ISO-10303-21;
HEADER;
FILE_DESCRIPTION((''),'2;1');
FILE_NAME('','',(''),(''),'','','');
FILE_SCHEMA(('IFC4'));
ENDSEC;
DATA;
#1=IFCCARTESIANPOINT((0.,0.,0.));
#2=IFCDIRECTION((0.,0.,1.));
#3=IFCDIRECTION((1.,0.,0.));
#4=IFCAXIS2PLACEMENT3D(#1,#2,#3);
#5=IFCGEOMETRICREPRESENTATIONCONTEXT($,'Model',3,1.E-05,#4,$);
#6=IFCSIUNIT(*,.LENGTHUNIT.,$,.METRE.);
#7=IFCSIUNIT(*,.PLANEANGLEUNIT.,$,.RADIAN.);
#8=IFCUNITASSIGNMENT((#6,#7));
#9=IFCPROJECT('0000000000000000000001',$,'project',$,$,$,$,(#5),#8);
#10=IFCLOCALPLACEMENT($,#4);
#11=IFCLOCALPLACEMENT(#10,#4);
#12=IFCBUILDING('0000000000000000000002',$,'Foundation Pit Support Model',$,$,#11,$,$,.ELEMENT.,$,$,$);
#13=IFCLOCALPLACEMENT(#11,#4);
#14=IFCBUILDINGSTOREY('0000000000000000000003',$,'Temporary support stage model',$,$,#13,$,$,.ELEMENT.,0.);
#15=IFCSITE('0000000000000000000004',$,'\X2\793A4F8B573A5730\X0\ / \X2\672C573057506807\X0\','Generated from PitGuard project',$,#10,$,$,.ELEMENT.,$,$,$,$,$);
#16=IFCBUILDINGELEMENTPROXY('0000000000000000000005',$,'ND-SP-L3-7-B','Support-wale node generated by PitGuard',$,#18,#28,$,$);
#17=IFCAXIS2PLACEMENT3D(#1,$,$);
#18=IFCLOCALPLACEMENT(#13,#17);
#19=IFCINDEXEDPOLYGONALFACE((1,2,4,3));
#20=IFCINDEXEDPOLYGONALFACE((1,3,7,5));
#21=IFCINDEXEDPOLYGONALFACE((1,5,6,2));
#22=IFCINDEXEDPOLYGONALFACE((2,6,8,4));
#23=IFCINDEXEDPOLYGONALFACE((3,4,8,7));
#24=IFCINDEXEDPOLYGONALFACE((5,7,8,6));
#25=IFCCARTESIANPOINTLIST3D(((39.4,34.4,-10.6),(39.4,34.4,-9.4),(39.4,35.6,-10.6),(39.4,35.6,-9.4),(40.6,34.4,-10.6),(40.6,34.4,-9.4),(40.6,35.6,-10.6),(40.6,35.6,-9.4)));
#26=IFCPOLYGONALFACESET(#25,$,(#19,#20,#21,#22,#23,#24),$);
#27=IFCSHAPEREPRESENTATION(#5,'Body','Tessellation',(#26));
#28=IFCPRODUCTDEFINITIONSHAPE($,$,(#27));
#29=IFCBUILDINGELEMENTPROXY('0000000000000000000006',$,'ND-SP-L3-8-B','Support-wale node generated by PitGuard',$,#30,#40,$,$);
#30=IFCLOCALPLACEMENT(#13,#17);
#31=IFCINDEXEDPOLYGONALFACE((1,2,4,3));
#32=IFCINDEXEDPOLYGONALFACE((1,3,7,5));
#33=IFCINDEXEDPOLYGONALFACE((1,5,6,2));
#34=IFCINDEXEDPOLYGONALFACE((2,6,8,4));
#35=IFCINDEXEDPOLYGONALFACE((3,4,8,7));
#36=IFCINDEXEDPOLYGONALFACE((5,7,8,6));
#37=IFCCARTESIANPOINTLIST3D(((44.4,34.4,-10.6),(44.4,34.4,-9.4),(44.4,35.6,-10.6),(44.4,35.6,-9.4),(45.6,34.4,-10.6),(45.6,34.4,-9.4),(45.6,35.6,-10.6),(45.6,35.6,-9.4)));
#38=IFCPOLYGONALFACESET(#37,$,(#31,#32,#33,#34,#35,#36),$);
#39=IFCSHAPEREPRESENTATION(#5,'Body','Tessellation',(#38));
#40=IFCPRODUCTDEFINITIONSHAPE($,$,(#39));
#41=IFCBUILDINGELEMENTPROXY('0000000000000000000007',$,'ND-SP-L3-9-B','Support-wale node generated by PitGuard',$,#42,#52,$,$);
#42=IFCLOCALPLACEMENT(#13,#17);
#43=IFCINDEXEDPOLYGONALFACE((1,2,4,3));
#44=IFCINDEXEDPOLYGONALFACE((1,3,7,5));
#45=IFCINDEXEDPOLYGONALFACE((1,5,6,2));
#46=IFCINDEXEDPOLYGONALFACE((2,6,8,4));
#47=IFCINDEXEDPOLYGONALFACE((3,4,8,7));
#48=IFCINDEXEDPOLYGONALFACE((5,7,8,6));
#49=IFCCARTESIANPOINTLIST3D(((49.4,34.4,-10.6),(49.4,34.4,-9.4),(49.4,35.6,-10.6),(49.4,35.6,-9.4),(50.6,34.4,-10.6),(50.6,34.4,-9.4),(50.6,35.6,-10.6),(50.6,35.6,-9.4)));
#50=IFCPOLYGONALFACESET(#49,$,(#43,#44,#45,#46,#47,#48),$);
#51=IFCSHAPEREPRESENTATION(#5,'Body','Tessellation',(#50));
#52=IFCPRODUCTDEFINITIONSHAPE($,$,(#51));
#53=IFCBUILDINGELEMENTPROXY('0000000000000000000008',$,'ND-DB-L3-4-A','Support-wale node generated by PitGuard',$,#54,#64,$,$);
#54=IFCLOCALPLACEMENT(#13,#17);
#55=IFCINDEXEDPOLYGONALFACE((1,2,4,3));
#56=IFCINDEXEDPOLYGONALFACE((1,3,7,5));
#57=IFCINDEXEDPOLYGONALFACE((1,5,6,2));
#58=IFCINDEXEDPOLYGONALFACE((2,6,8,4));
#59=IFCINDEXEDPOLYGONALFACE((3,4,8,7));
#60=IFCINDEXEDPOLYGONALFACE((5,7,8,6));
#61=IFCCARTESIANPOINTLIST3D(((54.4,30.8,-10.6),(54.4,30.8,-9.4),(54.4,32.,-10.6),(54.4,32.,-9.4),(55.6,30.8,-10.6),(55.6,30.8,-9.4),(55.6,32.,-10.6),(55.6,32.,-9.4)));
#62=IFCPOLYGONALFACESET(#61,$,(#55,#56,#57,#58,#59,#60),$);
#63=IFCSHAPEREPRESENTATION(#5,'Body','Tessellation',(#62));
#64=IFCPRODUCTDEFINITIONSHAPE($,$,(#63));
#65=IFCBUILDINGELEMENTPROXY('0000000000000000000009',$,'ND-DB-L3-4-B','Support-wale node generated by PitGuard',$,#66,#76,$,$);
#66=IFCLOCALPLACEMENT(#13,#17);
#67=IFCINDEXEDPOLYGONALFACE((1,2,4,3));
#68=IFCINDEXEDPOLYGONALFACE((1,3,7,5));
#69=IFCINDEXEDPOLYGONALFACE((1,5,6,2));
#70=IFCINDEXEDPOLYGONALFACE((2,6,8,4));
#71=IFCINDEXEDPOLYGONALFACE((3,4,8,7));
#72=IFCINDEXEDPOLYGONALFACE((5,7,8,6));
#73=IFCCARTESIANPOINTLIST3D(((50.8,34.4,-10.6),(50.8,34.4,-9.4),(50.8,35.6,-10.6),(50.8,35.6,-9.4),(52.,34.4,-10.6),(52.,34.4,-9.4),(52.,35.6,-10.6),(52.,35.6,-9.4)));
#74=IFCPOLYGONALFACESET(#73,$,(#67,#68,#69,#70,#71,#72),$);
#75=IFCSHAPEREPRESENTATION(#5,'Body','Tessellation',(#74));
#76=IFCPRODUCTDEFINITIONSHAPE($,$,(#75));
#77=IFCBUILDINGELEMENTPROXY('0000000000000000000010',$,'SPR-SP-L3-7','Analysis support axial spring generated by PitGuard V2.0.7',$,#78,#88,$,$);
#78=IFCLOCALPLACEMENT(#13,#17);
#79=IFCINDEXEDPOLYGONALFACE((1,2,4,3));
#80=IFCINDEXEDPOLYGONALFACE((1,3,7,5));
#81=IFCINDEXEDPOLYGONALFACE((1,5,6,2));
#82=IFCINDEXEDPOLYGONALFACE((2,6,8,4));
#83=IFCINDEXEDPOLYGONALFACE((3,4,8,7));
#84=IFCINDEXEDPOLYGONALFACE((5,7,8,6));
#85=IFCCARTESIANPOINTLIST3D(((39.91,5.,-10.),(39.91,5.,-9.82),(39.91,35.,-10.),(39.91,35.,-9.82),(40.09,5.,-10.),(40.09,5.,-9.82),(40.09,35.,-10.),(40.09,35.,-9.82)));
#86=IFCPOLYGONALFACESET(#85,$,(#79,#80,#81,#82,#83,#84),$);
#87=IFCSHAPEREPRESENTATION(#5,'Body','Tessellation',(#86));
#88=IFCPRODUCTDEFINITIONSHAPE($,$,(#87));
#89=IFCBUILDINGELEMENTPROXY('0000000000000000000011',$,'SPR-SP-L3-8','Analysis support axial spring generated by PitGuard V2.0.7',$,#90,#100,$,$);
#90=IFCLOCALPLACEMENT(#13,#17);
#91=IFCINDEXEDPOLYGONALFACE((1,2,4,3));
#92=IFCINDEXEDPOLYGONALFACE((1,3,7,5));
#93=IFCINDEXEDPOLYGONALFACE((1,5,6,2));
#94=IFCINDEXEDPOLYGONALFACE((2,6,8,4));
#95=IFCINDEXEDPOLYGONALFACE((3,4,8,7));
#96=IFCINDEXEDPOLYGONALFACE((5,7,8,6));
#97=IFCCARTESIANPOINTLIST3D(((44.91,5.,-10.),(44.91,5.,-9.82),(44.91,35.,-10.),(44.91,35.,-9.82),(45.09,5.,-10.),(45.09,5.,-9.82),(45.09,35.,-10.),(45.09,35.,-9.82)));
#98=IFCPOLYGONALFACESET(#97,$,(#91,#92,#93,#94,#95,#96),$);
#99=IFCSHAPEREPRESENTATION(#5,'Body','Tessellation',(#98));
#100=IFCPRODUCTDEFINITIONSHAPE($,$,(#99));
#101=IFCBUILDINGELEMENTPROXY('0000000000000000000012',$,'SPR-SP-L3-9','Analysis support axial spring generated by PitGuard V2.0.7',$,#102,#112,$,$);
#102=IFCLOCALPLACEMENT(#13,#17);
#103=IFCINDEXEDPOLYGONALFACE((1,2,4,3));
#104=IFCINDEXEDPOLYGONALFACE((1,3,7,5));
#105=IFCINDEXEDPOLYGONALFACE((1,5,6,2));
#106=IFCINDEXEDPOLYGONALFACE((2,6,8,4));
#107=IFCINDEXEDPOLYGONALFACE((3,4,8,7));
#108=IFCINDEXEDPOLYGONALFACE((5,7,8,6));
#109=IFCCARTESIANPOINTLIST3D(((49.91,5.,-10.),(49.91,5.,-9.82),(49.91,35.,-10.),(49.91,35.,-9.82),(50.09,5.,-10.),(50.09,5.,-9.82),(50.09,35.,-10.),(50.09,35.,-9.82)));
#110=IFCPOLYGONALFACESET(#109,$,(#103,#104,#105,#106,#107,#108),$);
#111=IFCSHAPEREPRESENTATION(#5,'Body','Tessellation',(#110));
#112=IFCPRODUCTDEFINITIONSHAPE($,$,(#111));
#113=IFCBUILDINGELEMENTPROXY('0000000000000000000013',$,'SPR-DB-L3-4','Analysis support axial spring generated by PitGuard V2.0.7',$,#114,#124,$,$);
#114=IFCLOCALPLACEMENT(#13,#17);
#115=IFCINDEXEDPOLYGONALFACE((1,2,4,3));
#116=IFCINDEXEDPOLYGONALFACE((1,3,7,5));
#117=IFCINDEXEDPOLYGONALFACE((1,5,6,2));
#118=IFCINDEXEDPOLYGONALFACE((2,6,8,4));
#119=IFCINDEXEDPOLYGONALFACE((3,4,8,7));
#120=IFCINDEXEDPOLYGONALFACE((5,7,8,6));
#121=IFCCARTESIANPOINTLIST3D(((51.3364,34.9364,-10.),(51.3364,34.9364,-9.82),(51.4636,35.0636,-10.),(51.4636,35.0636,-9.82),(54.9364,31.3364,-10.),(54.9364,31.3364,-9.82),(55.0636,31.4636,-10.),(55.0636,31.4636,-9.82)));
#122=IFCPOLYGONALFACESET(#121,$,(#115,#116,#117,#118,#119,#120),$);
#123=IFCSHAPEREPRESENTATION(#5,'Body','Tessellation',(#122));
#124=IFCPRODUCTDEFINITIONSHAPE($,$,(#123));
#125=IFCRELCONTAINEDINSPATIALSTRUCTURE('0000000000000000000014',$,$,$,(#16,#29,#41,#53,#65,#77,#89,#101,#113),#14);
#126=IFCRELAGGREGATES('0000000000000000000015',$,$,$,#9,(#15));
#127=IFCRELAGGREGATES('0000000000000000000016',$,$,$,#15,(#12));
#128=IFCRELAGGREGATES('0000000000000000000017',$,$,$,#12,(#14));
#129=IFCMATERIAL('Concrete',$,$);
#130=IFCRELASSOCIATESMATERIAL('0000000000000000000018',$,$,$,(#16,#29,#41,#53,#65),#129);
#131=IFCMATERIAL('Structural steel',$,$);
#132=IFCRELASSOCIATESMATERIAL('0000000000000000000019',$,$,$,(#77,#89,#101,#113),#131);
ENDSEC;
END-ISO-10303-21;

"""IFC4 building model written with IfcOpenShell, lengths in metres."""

from ifc_helpers import new_model, si_unit, frame, origin_with_axes, origin_2d, place, context, project, spatial, rectangle, extrude, material, element, save


model = new_model("IFC4")

# Units and contexts
model_context = context("Model", 3, precision=1e-05, world=origin_with_axes())
ifc_project = project(units=[si_unit("LENGTHUNIT", "METRE"), si_unit("PLANEANGLEUNIT", "RADIAN")], contexts=[model_context])

# Site, building, storey
site_placement = place(None, origin_with_axes())
site = spatial("IfcSite", under=ifc_project, at=site_placement, Name="示例场地 / 本地坐标", Description="Generated from PitGuard project", CompositionType="ELEMENT")
building_placement = place(site_placement, origin_with_axes())
building = spatial("IfcBuilding", under=site, at=building_placement, Name="Foundation Pit Support Model", CompositionType="ELEMENT")
storey_placement = place(building_placement, origin_with_axes())
storey = spatial("IfcBuildingStorey", under=building, at=storey_placement, Name="Temporary support stage model", CompositionType="ELEMENT", Elevation=0.0)

# Shared definitions
ifc_material_1 = material(Name="Structural steel")

# Shared definitions
ifc_material_2 = material(Name="Concrete")

# Building element proxies
for number, where, z_axis, x_axis, name in (
    (1, (40.0, 35.0, -10.6), (0.0, 0.0, 1.0), (1.0, 0.0, 0.0), "ND-SP-L3-7-B"),
    (2, (45.0, 35.0, -10.6), (0.0, 0.0, 1.0), (1.0, 0.0, 0.0), "ND-SP-L3-8-B"),
    (3, (50.0, 35.0, -10.6), (0.0, 0.0, 1.0), (1.0, 0.0, 0.0), "ND-SP-L3-9-B"),
    (4, (55.0, 31.4, -10.6), (0.0, 0.0, 1.0), (1.0, 0.0, 0.0), "ND-DB-L3-4-A"),
    (5, (51.4, 35.0, -10.6), (0.0, 0.0, 1.0), (1.0, 0.0, 0.0), "ND-DB-L3-4-B"),
):
    element("IfcBuildingElementProxy", number, at=place(storey_placement, frame(where, z_axis=z_axis, x_axis=x_axis)), inside=storey, material=ifc_material_2, Name=name, Description="Support-wale node generated by PitGuard", context=model_context, shape_type="SweptSolid", body=[
        extrude(rectangle(XDim=1.2, YDim=1.2, at=origin_2d()), origin_with_axes(), (0.0, 0.0, 1.0), 1.2),
    ])
for number, where, z_axis, x_axis, name in (
    (6, (40.0, 20.0, -10.0), (0.0, 0.0, 1.0), (0.0, 1.0, 0.0), "SPR-SP-L3-7"),
    (7, (45.0, 20.0, -10.0), (0.0, 0.0, 1.0), (0.0, 1.0, 0.0), "SPR-SP-L3-8"),
    (8, (50.0, 20.0, -10.0), (0.0, 0.0, 1.0), (0.0, 1.0, 0.0), "SPR-SP-L3-9"),
):
    element("IfcBuildingElementProxy", number, at=place(storey_placement, frame(where, z_axis=z_axis, x_axis=x_axis)), inside=storey, material=ifc_material_1, Name=name, Description="Analysis support axial spring generated by PitGuard V2.0.7", context=model_context, shape_type="SweptSolid", body=[
        extrude(rectangle(XDim=30.0, YDim=0.18, at=origin_2d()), origin_with_axes(), (0.0, 0.0, 1.0), 0.18),
    ])
proxy_placement = place(storey_placement, frame((53.2, 33.2, -10.0), z_axis=(0.0, 0.0, 1.0), x_axis=(-0.707107, 0.707107, 0.0)))
element("IfcBuildingElementProxy", 9, at=proxy_placement, inside=storey, material=ifc_material_1, Name="SPR-DB-L3-4", Description="Analysis support axial spring generated by PitGuard V2.0.7", context=model_context, shape_type="SweptSolid", body=[
    extrude(rectangle(XDim=5.0912, YDim=0.18, at=origin_2d()), origin_with_axes(), (0.0, 0.0, 1.0), 0.18),
])

save(model, "model.ifc")
